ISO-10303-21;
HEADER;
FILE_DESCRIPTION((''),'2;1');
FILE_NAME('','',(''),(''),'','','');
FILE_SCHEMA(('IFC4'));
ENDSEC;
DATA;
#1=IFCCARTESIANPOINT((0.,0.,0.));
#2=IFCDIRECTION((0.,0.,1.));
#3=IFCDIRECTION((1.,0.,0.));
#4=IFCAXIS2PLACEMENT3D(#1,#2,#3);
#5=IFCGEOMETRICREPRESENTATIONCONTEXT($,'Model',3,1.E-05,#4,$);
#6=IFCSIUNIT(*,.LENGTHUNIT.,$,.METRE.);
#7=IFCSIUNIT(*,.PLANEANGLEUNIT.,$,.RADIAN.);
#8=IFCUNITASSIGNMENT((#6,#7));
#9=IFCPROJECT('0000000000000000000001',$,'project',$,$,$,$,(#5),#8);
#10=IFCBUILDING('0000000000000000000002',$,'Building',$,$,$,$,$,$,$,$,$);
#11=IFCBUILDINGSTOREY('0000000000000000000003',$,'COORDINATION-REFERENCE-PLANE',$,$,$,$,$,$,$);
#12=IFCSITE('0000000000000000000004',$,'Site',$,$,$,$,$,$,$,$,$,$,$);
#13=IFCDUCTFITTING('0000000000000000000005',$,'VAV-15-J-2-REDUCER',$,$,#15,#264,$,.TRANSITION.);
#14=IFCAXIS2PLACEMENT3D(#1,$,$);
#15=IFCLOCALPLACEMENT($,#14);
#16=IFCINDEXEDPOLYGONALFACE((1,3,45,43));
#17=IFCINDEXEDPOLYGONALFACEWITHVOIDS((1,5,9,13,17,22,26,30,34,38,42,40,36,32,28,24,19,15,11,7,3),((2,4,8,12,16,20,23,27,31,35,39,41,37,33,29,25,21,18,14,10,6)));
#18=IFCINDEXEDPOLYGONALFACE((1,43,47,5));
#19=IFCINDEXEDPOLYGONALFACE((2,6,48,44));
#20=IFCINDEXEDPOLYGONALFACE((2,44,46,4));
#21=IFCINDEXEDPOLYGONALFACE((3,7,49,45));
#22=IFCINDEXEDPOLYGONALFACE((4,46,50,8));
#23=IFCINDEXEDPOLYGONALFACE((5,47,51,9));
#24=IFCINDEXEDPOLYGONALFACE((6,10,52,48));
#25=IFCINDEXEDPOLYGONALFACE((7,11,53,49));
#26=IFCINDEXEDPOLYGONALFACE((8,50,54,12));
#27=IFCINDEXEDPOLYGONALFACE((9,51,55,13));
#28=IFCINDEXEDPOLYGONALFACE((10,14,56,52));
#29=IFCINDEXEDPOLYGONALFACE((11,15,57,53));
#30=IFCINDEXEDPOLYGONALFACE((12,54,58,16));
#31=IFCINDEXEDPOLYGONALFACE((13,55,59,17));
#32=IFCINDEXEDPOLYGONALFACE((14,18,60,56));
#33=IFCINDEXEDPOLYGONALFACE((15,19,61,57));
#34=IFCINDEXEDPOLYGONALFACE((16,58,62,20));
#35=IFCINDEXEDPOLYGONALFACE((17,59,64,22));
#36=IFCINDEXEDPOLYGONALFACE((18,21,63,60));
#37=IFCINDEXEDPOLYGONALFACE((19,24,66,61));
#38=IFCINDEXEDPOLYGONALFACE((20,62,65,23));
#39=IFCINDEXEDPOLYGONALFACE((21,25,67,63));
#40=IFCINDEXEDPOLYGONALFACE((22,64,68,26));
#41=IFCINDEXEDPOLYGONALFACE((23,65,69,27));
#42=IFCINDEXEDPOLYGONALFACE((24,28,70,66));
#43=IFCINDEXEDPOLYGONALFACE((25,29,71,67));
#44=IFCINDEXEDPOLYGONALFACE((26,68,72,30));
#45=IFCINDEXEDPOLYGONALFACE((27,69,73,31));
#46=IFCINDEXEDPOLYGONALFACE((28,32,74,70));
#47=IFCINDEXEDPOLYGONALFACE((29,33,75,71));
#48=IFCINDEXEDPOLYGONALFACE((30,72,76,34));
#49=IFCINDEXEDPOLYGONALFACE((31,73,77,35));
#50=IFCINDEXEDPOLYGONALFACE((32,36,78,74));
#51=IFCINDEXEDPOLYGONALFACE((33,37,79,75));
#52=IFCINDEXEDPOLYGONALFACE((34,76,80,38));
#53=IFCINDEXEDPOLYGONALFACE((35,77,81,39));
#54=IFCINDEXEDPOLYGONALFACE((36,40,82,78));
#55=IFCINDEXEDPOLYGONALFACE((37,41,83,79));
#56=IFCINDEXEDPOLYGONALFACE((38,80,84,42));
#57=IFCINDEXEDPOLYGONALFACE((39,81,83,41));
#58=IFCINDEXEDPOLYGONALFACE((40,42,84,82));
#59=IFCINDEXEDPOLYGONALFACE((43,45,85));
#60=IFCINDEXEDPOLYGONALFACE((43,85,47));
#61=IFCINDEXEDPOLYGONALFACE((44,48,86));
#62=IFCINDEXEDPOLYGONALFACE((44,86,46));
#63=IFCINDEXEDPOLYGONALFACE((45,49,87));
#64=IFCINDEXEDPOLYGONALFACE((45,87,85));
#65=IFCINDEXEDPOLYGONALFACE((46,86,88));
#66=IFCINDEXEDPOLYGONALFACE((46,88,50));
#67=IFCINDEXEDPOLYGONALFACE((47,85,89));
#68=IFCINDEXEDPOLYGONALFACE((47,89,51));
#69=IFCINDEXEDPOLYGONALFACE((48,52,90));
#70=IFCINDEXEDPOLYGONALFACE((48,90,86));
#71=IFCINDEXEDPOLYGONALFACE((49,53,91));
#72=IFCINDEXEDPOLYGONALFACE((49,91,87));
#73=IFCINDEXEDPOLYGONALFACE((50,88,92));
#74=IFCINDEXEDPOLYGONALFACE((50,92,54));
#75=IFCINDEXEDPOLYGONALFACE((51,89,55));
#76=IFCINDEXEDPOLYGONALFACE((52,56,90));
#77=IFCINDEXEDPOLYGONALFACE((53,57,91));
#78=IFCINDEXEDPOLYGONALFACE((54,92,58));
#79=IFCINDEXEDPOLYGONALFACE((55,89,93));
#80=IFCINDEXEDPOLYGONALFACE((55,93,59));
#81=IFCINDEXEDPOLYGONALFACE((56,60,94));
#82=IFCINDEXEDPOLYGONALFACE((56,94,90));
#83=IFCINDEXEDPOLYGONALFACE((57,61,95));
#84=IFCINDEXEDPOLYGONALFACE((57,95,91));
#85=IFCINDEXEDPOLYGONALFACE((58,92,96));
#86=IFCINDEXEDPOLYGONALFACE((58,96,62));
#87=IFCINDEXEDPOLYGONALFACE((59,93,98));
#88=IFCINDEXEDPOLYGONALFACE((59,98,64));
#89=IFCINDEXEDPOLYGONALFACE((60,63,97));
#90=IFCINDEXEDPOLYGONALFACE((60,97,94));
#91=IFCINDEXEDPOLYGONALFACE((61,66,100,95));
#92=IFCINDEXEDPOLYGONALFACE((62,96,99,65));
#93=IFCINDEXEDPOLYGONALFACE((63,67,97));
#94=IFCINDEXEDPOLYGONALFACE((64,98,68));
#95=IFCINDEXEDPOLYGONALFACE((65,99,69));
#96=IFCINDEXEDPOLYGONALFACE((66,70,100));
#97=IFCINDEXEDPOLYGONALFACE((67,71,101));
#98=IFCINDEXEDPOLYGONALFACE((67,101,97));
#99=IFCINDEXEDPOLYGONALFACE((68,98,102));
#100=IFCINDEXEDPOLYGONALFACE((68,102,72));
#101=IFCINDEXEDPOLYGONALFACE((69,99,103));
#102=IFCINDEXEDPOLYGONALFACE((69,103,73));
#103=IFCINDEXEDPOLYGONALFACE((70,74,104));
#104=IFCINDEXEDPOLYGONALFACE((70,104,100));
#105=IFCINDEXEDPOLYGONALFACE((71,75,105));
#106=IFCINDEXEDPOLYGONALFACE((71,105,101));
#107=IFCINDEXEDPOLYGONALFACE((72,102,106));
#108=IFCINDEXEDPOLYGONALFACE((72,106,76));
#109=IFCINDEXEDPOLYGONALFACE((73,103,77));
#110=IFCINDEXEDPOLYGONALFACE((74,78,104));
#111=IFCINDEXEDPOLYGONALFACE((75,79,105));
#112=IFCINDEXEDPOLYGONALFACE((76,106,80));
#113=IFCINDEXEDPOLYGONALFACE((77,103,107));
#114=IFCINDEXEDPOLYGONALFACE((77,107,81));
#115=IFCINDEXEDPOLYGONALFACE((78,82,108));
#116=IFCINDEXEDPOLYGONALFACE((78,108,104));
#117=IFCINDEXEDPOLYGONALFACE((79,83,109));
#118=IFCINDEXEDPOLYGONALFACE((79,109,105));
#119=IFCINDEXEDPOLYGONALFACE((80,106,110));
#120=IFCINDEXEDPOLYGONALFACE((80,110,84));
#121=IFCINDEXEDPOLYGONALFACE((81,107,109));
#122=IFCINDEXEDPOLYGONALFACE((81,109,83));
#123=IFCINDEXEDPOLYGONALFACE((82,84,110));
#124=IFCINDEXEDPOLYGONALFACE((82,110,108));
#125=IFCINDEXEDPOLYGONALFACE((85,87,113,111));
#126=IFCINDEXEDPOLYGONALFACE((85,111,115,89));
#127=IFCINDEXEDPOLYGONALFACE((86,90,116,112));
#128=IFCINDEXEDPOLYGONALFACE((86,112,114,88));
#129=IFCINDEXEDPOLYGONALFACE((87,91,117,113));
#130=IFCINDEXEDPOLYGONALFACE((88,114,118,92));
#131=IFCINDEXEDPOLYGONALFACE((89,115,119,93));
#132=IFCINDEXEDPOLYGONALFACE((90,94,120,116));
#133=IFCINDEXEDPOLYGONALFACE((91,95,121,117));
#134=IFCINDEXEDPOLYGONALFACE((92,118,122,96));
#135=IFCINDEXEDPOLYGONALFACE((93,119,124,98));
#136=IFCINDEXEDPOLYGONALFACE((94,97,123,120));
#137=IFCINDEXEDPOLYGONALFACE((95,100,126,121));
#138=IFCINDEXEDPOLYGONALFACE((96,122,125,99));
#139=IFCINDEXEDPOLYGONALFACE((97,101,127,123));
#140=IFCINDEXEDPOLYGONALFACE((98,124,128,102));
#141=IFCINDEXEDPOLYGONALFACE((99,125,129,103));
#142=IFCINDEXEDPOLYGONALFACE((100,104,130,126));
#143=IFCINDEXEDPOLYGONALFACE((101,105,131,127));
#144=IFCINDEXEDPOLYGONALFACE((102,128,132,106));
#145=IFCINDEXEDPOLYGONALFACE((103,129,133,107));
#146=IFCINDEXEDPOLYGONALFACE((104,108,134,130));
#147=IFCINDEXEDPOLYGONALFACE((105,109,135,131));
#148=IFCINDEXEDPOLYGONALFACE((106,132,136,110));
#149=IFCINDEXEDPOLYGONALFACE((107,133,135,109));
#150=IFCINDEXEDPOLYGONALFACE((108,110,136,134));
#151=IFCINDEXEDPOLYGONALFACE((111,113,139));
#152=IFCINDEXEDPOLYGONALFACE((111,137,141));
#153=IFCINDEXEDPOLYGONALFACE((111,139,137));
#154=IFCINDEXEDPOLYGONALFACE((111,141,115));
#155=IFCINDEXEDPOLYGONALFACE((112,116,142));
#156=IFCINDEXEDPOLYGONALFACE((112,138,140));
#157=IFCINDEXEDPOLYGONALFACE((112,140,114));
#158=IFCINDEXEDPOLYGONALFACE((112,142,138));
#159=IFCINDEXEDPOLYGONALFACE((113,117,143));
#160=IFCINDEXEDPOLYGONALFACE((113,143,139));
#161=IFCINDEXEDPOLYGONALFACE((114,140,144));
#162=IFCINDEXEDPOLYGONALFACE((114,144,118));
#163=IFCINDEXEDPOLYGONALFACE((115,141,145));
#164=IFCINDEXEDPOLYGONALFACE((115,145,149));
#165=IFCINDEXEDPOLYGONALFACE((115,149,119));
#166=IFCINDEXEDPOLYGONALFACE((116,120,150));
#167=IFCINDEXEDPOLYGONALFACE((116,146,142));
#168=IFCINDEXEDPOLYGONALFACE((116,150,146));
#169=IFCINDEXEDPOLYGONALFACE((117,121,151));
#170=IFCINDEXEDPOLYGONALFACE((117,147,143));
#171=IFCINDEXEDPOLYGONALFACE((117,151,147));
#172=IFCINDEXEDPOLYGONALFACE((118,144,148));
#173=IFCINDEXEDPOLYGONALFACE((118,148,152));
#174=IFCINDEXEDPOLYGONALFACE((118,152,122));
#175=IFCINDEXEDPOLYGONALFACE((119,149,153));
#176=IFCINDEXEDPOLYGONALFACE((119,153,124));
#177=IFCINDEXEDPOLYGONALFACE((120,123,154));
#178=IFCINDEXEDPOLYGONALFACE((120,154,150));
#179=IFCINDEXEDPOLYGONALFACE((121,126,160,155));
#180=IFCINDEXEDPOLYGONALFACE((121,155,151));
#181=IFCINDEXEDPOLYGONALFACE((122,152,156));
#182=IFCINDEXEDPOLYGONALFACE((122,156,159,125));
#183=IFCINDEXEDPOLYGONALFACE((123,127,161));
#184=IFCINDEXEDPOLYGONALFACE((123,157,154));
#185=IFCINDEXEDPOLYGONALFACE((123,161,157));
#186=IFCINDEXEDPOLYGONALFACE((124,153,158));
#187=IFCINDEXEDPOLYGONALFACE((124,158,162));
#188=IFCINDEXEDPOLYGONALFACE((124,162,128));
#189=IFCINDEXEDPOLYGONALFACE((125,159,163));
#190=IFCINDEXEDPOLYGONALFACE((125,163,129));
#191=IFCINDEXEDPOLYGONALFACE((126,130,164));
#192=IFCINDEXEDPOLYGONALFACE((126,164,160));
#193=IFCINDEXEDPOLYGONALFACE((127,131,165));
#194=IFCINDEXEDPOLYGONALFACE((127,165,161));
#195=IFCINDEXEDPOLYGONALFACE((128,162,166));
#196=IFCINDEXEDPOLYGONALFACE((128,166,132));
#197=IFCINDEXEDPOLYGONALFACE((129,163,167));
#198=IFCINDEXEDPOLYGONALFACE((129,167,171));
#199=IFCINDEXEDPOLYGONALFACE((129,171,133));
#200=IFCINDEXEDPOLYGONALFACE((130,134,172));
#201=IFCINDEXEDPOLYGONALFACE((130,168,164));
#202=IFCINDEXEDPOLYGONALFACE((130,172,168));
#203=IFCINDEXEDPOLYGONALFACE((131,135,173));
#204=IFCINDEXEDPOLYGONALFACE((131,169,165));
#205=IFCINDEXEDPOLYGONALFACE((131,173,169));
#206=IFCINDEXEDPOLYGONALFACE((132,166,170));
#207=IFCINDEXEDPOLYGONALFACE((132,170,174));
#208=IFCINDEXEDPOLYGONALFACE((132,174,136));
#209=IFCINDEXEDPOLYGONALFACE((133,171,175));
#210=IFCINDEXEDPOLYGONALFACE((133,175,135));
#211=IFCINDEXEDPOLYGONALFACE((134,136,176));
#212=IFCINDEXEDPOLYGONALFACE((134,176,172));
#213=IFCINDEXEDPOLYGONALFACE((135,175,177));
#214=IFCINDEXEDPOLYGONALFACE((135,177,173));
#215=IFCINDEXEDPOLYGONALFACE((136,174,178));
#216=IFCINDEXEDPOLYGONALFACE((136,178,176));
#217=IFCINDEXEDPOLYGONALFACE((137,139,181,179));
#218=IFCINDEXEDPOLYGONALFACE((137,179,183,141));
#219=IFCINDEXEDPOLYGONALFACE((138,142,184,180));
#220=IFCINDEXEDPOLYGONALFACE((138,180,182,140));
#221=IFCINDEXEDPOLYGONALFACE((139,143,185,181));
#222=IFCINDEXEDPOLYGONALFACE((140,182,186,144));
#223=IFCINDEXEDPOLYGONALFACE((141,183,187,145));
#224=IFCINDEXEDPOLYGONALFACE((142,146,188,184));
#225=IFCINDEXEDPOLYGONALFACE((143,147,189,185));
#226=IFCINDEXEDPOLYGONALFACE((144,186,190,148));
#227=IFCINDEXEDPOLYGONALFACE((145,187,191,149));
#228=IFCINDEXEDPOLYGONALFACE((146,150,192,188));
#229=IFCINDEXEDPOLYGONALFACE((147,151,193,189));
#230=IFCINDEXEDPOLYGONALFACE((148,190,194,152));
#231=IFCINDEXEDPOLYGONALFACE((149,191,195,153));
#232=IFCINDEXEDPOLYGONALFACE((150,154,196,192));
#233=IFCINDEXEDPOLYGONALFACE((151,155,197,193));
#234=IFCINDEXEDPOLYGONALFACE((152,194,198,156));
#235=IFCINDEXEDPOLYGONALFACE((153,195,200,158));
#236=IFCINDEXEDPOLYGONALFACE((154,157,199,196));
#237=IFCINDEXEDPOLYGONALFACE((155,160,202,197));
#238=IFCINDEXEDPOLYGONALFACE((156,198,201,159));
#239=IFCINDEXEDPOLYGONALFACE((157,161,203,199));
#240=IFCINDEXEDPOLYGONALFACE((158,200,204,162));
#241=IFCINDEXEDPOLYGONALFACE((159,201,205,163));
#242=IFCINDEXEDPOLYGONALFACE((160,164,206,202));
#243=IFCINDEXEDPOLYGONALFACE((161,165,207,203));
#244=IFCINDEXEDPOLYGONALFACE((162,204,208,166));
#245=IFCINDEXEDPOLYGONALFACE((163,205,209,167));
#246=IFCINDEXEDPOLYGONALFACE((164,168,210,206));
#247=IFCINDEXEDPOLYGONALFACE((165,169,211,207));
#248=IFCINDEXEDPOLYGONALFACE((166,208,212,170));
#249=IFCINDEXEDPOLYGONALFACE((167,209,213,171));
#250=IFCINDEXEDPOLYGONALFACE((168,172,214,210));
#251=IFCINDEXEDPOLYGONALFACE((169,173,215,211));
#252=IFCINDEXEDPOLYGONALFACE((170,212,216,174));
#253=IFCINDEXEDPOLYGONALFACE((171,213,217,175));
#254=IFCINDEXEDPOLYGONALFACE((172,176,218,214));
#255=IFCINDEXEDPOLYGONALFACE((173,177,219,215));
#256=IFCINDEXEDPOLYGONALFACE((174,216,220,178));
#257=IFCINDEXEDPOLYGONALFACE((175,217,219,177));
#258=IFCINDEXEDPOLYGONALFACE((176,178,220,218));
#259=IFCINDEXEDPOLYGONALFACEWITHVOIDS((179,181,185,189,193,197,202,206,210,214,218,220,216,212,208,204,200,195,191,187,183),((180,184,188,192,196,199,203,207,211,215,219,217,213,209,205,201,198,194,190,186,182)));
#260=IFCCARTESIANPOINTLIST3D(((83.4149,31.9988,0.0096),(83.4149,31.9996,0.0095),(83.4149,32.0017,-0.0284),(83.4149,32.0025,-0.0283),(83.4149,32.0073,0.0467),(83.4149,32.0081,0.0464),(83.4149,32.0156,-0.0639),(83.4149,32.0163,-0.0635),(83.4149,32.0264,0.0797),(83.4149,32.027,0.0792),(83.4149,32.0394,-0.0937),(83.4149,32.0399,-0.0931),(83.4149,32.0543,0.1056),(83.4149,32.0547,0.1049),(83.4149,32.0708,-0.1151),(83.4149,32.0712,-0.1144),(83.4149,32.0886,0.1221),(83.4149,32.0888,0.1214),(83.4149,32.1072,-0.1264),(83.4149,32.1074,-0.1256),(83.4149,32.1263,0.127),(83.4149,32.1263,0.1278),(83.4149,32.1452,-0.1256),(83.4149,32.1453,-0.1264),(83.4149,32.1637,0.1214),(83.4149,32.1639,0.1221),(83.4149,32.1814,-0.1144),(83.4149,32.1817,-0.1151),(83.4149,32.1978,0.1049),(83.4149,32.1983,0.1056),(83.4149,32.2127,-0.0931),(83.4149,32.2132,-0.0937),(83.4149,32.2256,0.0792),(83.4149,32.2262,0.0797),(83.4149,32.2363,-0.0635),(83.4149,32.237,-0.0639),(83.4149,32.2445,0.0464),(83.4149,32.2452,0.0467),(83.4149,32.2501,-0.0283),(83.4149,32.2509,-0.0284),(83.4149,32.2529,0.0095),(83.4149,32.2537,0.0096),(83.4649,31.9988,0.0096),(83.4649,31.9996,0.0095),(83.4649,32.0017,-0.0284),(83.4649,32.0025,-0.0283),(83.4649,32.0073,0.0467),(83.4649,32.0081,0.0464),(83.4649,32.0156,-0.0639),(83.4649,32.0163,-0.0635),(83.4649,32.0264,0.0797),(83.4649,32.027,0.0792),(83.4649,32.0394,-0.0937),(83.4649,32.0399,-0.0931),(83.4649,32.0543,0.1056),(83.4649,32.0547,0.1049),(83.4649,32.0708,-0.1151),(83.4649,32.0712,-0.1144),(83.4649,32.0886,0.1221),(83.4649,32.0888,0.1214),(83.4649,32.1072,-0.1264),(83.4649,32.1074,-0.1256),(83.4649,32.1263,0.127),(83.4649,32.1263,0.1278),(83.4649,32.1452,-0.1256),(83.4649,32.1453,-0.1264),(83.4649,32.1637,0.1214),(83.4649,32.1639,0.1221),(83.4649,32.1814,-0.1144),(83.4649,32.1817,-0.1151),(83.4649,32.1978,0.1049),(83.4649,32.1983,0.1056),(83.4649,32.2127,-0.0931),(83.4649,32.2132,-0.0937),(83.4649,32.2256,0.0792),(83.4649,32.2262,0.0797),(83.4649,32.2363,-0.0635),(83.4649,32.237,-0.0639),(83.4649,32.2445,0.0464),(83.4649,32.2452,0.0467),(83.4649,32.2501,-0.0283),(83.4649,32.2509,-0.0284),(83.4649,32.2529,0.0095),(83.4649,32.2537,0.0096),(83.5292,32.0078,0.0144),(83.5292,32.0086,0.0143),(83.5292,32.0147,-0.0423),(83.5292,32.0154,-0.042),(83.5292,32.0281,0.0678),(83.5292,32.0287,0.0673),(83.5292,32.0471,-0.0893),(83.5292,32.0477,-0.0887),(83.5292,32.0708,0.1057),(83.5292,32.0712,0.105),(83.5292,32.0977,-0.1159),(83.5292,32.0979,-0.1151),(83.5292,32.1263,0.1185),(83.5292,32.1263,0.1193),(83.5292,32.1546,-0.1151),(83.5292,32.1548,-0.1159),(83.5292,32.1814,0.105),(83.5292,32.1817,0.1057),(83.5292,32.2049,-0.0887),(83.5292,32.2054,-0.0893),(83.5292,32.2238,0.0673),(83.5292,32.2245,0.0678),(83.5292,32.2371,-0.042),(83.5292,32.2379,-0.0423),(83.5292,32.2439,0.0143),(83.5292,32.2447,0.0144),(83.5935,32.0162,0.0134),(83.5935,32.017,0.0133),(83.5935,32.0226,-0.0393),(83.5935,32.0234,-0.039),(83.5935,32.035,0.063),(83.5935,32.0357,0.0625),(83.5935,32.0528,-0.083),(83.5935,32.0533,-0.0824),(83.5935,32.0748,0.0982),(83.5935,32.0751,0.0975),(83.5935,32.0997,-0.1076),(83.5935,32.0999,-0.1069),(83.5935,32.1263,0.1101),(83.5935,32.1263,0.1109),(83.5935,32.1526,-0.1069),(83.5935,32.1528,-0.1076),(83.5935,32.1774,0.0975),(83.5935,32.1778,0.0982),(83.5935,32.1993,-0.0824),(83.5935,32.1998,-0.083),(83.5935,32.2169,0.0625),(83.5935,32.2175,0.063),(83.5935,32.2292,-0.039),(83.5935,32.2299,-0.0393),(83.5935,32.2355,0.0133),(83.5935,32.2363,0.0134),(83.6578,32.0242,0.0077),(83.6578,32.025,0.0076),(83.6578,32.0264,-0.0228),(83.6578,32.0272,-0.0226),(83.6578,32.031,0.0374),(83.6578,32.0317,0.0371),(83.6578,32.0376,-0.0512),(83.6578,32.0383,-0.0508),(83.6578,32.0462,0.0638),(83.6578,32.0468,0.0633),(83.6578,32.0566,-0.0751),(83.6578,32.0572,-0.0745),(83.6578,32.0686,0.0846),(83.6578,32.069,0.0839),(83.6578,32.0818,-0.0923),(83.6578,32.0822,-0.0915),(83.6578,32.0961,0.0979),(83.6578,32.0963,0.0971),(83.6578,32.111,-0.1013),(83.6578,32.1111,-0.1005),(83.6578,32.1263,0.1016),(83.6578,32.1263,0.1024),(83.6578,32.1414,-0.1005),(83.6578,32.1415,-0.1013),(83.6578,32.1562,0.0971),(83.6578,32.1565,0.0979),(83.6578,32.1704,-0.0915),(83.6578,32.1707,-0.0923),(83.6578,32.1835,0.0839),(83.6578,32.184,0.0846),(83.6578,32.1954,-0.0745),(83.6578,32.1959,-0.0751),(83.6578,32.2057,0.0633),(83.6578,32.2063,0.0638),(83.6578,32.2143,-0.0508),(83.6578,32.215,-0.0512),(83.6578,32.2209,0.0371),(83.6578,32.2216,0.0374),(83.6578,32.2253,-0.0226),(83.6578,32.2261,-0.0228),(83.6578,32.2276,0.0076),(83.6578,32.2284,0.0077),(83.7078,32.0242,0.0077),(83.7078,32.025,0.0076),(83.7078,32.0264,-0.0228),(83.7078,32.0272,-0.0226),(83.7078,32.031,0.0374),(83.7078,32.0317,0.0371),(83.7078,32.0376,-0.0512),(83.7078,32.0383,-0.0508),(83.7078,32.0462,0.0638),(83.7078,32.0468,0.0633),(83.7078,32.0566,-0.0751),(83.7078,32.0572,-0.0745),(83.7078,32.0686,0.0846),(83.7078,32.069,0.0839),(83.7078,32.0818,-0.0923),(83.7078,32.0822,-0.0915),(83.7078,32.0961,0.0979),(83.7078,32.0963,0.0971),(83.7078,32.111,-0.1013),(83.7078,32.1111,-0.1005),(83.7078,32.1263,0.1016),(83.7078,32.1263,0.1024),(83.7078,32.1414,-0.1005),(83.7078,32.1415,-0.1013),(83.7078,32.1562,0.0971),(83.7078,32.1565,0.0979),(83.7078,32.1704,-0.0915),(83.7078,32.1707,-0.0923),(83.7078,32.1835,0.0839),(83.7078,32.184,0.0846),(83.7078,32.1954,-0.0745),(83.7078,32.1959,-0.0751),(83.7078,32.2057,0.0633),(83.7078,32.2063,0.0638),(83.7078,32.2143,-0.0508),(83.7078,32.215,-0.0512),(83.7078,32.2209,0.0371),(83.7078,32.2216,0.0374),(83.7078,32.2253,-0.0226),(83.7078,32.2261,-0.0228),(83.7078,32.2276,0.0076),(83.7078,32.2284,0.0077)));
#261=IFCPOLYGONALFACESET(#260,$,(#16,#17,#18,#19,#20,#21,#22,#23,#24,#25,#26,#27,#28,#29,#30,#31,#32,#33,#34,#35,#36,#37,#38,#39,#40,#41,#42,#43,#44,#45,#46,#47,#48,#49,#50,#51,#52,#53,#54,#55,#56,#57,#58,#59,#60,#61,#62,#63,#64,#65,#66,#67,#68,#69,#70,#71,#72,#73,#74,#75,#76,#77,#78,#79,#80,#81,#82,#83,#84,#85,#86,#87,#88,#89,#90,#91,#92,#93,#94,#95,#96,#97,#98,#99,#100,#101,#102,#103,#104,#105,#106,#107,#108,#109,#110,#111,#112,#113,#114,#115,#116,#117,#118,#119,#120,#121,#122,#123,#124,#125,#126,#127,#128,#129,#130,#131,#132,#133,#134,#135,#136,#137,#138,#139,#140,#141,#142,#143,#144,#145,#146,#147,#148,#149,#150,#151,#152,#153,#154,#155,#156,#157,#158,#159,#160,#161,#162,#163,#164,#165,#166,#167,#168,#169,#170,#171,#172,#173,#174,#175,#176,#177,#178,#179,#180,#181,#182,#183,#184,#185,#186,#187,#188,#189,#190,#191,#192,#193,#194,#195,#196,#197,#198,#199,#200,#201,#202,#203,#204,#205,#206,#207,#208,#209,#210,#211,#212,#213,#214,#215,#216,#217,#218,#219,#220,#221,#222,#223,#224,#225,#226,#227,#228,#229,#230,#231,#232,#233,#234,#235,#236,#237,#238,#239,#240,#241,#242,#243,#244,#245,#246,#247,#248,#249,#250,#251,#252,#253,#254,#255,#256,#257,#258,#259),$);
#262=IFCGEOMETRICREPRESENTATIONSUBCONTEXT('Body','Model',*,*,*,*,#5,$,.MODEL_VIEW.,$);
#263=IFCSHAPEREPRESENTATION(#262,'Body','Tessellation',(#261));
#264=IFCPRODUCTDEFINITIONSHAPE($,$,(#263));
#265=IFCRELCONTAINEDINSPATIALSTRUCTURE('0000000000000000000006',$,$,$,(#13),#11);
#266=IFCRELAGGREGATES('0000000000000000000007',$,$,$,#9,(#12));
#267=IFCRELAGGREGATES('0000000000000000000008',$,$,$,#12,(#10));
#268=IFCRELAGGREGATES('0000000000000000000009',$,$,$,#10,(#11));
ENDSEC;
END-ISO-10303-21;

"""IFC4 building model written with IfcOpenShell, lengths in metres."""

from ifc_helpers import new_model, entity, si_unit, frame, origin_with_axes, place, context, subcontext, project, spatial, element, save


model = new_model("IFC4")

# Units and contexts
model_context_1 = context("Model", 3, precision=1e-05, world=origin_with_axes())
body_context_1 = subcontext(model_context_1, "Body", "Model", "MODEL_VIEW")
ifc_project = project(units=[si_unit("LENGTHUNIT", "METRE"), si_unit("PLANEANGLEUNIT", "RADIAN")], contexts=[model_context_1])

# Site, building, storey
site = spatial("IfcSite", under=ifc_project, Name="Site")
building = spatial("IfcBuilding", under=site, Name="Building")
storey = spatial("IfcBuildingStorey", under=building, Name="COORDINATION-REFERENCE-PLANE")

# Duct fitting
for number, where, z_axis, x_axis, name in (
    (1, (83.4149, 32.1263, 0.0), (0.0, 1.0, 0.0), (0.0, 0.0, 1.0), "VAV-15-J-2-REDUCER"),
):
    element("IfcDuctFitting", number, at=place(None, frame(where, z_axis=z_axis, x_axis=x_axis)), inside=storey, Name=name, PredefinedType="TRANSITION", context=body_context_1, shape_type="SweptSolid", body=[
        entity("IfcRevolvedAreaSolid", entity("IfcArbitraryClosedProfileDef", "AREA", None, entity("IfcPolyline", [entity("IfcCartesianPoint", [0.1278, 0.0]), entity("IfcCartesianPoint", [0.1278, 0.05]), entity("IfcCartesianPoint", [0.1024, 0.2429]), entity("IfcCartesianPoint", [0.1024, 0.2929]), entity("IfcCartesianPoint", [0.1016, 0.2929]), entity("IfcCartesianPoint", [0.1016, 0.2429]), entity("IfcCartesianPoint", [0.127, 0.05]), entity("IfcCartesianPoint", [0.127, 0.0]), entity("IfcCartesianPoint", [0.1278, 0.0])])), entity("IfcAxis2Placement3D", entity("IfcCartesianPoint", [0.0, 0.0, 0.0])), entity("IfcAxis1Placement", entity("IfcCartesianPoint", [0.0, 0.0, 0.0]), entity("IfcDirection", [0.0, 1.0, 0.0])), 6.283185),
    ])

save(model, "model.ifc")
